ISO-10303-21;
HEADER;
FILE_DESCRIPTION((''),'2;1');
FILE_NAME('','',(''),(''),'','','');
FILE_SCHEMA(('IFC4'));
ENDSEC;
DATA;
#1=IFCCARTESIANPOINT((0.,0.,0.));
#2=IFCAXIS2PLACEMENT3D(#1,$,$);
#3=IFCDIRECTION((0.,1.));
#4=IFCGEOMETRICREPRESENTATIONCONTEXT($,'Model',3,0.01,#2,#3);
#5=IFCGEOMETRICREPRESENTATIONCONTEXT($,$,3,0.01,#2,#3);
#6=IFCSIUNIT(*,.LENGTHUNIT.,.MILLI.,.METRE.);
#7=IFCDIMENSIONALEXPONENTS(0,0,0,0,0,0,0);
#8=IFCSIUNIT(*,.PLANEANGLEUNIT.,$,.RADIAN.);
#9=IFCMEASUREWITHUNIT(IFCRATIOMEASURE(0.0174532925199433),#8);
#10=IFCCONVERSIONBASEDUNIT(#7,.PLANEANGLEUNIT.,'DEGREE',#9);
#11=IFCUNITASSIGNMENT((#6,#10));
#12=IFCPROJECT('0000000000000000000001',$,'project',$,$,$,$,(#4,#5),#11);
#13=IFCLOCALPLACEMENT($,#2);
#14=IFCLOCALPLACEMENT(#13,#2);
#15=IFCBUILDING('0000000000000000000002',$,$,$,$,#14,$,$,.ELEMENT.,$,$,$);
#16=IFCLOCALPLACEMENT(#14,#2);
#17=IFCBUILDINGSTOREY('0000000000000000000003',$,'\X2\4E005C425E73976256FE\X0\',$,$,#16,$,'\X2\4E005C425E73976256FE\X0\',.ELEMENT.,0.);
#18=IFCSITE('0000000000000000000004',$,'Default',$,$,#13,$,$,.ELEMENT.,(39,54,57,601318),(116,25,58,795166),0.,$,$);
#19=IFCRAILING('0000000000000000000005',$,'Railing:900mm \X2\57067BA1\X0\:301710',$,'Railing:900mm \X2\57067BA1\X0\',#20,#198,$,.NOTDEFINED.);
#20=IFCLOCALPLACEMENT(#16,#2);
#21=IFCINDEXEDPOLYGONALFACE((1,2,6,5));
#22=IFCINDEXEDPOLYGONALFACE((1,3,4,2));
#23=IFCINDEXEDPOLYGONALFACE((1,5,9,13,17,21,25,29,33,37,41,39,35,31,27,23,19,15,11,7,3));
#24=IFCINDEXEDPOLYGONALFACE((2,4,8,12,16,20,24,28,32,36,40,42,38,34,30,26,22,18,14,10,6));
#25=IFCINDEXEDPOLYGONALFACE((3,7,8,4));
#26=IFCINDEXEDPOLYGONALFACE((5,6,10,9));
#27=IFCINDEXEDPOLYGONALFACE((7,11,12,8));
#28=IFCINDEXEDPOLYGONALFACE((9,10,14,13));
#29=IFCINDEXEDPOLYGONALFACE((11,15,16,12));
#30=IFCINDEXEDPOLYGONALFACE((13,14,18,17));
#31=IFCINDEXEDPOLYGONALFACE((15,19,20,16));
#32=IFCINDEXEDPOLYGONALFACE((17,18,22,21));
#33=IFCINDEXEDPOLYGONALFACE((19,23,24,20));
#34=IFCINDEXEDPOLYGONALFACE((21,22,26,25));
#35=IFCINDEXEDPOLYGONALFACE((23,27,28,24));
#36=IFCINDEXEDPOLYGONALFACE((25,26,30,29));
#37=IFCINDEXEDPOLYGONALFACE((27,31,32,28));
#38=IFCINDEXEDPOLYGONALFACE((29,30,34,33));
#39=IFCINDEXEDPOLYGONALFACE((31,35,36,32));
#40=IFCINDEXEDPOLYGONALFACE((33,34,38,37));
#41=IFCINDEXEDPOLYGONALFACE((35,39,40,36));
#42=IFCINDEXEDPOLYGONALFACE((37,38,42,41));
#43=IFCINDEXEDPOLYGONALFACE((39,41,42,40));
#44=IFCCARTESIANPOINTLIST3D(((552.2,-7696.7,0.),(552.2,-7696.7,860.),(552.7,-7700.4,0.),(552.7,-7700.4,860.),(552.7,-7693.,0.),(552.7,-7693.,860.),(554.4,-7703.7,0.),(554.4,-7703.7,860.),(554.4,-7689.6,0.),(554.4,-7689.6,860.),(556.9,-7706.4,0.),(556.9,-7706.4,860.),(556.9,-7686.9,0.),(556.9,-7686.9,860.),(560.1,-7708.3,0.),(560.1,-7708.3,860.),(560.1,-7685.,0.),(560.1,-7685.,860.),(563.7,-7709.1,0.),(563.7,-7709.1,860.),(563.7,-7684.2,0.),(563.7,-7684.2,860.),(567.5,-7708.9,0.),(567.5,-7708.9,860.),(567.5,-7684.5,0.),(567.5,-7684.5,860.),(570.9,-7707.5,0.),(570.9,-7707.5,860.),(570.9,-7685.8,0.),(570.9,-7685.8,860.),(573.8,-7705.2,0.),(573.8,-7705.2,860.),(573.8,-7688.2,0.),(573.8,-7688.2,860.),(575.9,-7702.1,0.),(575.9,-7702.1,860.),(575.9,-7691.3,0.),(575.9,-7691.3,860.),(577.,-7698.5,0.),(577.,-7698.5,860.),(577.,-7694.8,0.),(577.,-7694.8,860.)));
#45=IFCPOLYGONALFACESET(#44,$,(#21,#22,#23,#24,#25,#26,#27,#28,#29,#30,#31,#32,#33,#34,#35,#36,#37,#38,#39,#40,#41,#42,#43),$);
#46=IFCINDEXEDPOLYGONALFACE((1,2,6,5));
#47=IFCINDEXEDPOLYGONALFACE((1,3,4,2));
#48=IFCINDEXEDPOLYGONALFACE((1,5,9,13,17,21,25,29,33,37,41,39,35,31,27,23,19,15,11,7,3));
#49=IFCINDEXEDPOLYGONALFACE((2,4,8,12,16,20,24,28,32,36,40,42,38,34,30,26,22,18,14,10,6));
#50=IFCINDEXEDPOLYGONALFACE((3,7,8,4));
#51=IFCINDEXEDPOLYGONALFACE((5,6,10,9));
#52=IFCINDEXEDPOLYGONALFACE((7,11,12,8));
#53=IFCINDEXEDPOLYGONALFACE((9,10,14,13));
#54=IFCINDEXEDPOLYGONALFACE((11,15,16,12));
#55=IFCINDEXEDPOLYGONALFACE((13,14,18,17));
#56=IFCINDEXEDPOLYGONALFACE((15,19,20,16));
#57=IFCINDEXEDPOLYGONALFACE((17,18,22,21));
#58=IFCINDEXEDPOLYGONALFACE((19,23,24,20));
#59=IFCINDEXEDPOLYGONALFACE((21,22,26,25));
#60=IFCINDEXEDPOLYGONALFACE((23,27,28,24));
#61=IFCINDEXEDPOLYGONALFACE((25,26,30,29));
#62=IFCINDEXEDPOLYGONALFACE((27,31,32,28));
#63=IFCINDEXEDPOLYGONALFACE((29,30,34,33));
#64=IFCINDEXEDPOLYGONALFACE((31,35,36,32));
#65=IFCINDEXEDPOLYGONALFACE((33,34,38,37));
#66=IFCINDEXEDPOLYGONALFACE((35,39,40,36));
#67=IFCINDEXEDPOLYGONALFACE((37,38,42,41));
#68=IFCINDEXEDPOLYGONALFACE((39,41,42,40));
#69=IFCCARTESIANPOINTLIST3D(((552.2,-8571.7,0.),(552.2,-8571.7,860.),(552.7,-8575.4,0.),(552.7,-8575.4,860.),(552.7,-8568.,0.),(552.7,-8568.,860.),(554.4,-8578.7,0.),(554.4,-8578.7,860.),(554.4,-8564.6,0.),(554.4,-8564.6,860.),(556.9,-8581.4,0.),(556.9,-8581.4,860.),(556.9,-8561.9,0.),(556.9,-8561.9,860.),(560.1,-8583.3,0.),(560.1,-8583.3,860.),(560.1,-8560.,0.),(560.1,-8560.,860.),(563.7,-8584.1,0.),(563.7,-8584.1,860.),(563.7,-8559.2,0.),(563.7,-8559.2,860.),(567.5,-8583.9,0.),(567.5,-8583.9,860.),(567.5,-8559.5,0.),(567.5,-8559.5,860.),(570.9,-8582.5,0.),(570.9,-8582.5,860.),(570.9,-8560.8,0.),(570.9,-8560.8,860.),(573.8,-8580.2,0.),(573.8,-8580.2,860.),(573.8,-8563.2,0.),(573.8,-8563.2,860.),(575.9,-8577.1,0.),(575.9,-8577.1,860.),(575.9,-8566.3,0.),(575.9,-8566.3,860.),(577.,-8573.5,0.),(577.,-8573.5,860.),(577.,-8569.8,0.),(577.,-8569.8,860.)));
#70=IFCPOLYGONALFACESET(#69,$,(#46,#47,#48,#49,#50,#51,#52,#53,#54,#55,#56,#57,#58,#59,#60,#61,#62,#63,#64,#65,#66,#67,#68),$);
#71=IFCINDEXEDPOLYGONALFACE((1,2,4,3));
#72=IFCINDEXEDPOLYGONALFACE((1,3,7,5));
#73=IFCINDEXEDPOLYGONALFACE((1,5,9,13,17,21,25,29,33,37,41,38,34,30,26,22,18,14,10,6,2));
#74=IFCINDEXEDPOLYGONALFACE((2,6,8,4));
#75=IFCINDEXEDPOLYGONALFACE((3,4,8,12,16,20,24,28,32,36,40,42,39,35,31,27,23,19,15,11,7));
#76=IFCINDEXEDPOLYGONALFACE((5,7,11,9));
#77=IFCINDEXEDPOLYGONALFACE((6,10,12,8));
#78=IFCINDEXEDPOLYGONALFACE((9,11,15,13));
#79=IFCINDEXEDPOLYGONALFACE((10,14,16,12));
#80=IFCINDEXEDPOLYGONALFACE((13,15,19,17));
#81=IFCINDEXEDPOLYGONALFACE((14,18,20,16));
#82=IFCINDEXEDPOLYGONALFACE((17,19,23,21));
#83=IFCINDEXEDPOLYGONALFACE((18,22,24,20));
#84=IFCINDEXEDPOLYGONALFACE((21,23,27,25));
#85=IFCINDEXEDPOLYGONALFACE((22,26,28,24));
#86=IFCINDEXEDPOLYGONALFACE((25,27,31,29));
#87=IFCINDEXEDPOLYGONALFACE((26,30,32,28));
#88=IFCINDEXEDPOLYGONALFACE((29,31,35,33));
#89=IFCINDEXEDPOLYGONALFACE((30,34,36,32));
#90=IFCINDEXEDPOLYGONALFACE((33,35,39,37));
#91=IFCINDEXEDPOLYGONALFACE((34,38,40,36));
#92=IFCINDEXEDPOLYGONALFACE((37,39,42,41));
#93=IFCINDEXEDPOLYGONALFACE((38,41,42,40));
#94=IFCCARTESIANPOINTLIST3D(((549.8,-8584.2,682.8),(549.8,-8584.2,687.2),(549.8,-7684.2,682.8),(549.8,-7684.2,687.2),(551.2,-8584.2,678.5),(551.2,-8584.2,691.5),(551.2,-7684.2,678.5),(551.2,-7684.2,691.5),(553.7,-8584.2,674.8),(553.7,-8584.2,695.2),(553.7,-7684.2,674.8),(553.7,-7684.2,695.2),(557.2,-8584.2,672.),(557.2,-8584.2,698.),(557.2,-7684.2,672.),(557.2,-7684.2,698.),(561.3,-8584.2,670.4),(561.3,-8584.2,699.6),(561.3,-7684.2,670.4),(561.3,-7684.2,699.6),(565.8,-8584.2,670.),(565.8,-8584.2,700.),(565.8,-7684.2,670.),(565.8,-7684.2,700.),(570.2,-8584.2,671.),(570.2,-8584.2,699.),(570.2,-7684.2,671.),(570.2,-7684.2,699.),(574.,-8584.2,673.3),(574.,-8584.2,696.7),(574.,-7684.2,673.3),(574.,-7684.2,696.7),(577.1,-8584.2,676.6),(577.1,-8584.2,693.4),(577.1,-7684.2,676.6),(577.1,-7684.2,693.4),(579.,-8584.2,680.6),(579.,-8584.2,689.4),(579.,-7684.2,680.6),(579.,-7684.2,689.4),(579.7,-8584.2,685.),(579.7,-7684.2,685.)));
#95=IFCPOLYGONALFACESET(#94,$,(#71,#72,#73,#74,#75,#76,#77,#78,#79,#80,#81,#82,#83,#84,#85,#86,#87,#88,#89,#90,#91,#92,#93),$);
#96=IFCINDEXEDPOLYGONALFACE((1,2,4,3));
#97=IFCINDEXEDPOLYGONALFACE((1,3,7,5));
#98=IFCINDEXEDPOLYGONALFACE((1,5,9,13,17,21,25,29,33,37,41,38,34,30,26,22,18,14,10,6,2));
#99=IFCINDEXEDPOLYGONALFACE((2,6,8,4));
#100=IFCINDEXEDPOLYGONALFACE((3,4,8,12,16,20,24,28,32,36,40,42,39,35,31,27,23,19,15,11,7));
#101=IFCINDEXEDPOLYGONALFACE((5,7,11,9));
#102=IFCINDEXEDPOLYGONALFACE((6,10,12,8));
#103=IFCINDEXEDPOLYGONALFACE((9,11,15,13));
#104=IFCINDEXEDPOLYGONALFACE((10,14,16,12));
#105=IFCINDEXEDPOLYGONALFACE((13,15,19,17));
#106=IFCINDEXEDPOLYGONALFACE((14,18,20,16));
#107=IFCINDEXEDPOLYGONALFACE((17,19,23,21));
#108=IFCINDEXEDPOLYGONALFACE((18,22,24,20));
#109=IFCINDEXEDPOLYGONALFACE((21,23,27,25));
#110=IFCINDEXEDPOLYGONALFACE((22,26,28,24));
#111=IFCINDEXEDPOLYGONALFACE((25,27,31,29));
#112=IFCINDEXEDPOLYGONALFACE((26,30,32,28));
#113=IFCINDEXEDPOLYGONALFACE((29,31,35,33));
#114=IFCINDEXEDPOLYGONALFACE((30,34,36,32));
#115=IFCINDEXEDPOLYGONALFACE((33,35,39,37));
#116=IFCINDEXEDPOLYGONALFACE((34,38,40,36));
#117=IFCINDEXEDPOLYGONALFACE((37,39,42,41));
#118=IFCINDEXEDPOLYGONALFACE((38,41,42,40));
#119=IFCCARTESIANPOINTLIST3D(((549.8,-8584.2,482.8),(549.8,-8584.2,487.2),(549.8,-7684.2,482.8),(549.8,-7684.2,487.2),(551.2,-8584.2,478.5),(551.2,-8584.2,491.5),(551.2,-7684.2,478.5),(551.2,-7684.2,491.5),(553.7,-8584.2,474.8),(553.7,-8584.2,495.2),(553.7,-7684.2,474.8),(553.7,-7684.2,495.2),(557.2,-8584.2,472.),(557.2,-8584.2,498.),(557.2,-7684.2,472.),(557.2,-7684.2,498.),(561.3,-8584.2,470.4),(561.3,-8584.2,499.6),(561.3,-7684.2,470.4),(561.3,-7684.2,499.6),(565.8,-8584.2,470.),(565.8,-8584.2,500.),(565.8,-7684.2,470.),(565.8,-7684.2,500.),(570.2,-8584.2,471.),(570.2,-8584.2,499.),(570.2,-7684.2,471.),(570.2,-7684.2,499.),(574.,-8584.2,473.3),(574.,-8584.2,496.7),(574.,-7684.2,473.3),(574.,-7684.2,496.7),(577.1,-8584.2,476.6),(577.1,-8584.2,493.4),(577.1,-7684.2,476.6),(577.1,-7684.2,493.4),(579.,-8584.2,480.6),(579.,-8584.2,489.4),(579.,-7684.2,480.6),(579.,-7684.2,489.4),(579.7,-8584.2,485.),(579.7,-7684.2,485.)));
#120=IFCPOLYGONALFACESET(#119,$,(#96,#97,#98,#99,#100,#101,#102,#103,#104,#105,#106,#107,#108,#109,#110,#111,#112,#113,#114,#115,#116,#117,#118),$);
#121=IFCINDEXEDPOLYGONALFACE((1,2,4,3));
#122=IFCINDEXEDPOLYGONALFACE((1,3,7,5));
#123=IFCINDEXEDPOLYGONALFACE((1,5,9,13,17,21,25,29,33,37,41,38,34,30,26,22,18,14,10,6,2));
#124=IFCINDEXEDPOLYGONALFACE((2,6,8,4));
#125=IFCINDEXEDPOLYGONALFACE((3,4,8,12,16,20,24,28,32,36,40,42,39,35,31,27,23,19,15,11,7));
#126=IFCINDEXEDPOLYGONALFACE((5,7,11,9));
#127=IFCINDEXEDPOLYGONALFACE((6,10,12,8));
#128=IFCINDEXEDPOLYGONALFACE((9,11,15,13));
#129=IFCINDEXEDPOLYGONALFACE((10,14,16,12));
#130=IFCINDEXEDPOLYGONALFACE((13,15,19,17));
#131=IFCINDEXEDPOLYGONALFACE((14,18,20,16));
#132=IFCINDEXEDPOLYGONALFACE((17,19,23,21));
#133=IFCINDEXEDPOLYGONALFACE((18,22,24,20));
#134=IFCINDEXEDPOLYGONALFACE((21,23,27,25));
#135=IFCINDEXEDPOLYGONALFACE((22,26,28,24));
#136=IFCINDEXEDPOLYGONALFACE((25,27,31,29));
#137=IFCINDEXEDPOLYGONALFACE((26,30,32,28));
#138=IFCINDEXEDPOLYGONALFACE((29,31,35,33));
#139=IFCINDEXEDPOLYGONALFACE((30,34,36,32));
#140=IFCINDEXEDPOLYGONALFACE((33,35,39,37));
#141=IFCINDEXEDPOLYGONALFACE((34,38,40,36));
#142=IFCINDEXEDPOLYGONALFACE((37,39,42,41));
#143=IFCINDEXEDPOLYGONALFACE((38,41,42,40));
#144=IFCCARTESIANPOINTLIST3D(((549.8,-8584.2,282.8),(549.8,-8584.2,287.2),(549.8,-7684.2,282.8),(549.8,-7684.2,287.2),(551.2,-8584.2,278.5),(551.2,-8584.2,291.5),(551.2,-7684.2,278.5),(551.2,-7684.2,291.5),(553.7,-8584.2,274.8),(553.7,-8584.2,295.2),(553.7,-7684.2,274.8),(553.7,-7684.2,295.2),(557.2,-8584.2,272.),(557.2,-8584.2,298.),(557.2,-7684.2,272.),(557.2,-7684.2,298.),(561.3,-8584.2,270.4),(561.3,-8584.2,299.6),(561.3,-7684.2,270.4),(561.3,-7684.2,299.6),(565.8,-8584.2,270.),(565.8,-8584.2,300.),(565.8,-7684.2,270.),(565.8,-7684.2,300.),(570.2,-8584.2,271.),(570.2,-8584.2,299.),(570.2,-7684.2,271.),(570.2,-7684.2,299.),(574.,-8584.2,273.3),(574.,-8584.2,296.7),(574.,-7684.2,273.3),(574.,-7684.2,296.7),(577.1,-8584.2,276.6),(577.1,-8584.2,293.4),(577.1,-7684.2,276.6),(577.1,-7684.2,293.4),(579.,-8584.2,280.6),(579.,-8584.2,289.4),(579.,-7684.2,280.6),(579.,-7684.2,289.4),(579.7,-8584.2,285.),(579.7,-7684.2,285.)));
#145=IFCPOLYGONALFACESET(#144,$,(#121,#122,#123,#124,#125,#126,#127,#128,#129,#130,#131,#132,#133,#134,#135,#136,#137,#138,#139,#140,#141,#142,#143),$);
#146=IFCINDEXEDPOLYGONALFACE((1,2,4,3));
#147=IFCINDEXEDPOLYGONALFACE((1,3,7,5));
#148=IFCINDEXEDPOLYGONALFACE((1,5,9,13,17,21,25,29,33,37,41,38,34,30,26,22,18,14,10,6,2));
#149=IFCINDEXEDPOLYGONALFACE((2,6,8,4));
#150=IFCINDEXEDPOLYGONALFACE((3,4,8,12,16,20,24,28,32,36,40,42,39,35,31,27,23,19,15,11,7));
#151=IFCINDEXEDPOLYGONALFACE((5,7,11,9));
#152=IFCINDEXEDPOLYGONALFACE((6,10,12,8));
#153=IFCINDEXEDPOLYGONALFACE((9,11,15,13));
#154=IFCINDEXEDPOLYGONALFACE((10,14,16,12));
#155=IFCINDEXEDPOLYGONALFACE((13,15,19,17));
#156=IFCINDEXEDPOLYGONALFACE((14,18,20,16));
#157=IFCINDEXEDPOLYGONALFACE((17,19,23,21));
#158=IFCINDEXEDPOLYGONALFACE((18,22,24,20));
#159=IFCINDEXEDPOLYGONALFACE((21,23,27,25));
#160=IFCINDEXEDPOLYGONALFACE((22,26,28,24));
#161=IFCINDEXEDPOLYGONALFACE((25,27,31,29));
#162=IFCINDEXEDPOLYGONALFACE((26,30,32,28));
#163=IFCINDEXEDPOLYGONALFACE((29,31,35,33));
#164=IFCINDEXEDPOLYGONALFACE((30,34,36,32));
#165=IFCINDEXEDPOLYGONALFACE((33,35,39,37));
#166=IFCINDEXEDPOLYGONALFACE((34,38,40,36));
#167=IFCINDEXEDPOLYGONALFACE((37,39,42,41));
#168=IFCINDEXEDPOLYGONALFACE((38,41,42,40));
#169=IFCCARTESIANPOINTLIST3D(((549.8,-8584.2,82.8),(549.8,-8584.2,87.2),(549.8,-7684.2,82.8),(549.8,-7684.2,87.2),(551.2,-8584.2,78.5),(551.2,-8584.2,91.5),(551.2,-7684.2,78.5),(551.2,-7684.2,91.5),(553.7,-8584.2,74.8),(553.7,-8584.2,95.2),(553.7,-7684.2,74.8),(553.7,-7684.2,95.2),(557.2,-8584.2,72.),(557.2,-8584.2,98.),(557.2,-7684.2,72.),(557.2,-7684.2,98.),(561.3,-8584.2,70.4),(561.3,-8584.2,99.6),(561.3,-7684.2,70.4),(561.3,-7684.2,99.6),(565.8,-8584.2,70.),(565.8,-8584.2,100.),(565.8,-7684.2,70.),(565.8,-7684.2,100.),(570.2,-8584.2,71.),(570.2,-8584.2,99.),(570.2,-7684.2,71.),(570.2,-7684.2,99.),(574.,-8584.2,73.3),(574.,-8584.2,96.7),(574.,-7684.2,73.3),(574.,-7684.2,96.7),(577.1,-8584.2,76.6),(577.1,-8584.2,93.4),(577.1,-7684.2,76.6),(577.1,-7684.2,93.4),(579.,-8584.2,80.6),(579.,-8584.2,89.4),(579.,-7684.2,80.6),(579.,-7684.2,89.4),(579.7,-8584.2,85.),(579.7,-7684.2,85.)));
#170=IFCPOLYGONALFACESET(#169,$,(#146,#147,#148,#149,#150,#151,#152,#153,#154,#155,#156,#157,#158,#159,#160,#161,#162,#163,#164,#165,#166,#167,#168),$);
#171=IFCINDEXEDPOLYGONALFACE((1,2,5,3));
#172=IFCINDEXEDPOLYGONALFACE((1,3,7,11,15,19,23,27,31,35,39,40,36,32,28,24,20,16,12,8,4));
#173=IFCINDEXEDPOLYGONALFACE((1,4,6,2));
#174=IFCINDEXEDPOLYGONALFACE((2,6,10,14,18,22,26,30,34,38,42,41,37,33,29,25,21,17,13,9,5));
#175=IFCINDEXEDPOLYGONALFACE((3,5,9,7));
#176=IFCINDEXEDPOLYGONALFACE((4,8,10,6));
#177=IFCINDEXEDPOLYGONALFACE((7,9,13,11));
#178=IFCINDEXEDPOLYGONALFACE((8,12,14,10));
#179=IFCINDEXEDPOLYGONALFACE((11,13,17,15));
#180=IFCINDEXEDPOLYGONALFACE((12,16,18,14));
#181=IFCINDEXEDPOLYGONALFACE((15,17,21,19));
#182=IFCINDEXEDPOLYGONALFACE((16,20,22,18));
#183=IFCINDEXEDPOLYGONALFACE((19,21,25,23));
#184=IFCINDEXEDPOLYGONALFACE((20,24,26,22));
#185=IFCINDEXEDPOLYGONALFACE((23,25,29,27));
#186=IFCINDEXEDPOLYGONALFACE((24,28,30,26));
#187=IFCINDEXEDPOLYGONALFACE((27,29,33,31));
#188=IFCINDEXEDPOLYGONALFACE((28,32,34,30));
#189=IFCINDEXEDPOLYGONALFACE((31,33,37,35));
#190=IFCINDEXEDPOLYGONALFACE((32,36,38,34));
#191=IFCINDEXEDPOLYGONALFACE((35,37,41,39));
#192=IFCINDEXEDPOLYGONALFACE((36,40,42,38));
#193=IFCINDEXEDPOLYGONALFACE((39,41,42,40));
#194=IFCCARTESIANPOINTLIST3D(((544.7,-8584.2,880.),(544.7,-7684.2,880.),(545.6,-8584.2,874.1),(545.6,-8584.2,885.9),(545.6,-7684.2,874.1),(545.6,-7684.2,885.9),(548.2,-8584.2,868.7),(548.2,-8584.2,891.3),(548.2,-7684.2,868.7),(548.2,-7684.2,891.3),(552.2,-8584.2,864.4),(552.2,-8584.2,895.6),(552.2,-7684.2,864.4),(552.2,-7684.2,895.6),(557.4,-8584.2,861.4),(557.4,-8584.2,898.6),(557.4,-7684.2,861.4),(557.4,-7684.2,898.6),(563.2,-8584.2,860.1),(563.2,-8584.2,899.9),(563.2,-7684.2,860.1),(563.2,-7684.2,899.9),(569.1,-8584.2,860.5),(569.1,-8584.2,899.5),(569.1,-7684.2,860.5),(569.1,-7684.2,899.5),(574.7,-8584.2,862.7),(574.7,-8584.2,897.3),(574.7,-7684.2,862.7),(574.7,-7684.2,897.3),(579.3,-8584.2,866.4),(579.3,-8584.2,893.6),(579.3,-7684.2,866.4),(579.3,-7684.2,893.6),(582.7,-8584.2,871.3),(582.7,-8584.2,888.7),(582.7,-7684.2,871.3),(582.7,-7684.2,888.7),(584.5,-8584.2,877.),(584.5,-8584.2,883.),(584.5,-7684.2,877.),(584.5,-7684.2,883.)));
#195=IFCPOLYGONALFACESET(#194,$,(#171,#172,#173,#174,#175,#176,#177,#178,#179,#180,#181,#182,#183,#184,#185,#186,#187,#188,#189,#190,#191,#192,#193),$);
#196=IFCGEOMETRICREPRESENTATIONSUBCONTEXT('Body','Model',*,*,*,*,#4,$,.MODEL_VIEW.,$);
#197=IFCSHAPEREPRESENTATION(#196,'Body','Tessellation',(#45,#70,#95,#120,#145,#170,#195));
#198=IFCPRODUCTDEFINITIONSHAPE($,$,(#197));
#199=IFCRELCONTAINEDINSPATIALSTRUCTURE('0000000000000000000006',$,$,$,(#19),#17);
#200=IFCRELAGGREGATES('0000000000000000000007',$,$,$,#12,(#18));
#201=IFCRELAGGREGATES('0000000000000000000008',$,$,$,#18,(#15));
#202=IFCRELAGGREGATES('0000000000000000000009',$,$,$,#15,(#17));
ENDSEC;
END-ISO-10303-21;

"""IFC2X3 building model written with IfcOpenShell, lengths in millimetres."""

from ifc_helpers import new_model, entity, si_unit, converted_unit, direction, frame, frame_2d, origin, origin_2d_with_axis, place, context, subcontext, project, spatial, circle, extrude, element, save


model = new_model("IFC2X3")

# Units and contexts
model_context = context("Model", 3, precision=0.01, world=origin(), true_north=direction((0.0, 1.0)))
context_of_model = context(None, 3, precision=0.01, world=origin(), true_north=direction((0.0, 1.0)))
body_context = subcontext(model_context, "Body", "Model", "MODEL_VIEW")
ifc_project = project(units=[si_unit("LENGTHUNIT", "METRE", prefix="MILLI"), converted_unit("PLANEANGLEUNIT", "DEGREE", entity("IfcRatioMeasure", 0.0174532925199433), si_unit("PLANEANGLEUNIT", "RADIAN"), dimensions=[0, 0, 0, 0, 0, 0, 0])], contexts=[model_context, context_of_model])

# Site, building, storey
site_placement = place(None, origin())
site = spatial("IfcSite", under=ifc_project, at=site_placement, Name="Default", CompositionType="ELEMENT", RefLatitude=(39, 54, 57, 601318), RefLongitude=(116, 25, 58, 795166), RefElevation=0.0)
building_placement = place(site_placement, origin())
building = spatial("IfcBuilding", under=site, at=building_placement, CompositionType="ELEMENT")
storey_placement = place(building_placement, origin())
storey = spatial("IfcBuildingStorey", under=building, at=storey_placement, Name="一层平面图", LongName="一层平面图", CompositionType="ELEMENT", Elevation=0.0)

# Railing
railing_placement = place(storey_placement, origin())
element("IfcRailing", 1, at=railing_placement, inside=storey, Name="Railing:900mm 圆管:301710", ObjectType="Railing:900mm 圆管", PredefinedType="NOTDEFINED", context=body_context, shape_type="SweptSolid", body=[
    extrude(circle(Radius=12.5, at=origin_2d_with_axis()), frame((564.7, -7696.7, 0.0), z_axis=(0.0, 0.0, 1.0), x_axis=(-1.0, 0.0, 0.0)), (0.0, 0.0, 1.0), 860.0),
    extrude(circle(Radius=12.5, at=origin_2d_with_axis()), frame((564.7, -8571.7, 0.0), z_axis=(0.0, 0.0, 1.0), x_axis=(-1.0, 0.0, 0.0)), (0.0, 0.0, 1.0), 860.0),
    extrude(circle(Radius=15.0, at=origin_2d_with_axis()), frame((564.7, -8584.2, 685.0), z_axis=(0.0, 1.0, 0.0), x_axis=(1.0, 0.0, 0.0)), (0.0, 0.0, 1.0), 900.0),
    extrude(circle(Radius=15.0, at=origin_2d_with_axis()), frame((564.7, -8584.2, 485.0), z_axis=(0.0, 1.0, 0.0), x_axis=(1.0, 0.0, 0.0)), (0.0, 0.0, 1.0), 900.0),
    extrude(circle(Radius=15.0, at=origin_2d_with_axis()), frame((564.7, -8584.2, 285.0), z_axis=(0.0, 1.0, 0.0), x_axis=(1.0, 0.0, 0.0)), (0.0, 0.0, 1.0), 900.0),
    extrude(circle(Radius=15.0, at=frame_2d((0.0, 0.0), x_axis=(1.0, 0.0))), frame((564.7, -8584.2, 85.0), z_axis=(0.0, 1.0, 0.0), x_axis=(1.0, 0.0, 0.0)), (0.0, 0.0, 1.0), 900.0),
    extrude(circle(Radius=20.0, at=origin_2d_with_axis()), frame((564.7, -8584.2, 880.0), z_axis=(0.0, 1.0, 0.0), x_axis=(-1.0, 0.0, 0.0)), (0.0, 0.0, 1.0), 900.0),
])

save(model, "model.ifc")
